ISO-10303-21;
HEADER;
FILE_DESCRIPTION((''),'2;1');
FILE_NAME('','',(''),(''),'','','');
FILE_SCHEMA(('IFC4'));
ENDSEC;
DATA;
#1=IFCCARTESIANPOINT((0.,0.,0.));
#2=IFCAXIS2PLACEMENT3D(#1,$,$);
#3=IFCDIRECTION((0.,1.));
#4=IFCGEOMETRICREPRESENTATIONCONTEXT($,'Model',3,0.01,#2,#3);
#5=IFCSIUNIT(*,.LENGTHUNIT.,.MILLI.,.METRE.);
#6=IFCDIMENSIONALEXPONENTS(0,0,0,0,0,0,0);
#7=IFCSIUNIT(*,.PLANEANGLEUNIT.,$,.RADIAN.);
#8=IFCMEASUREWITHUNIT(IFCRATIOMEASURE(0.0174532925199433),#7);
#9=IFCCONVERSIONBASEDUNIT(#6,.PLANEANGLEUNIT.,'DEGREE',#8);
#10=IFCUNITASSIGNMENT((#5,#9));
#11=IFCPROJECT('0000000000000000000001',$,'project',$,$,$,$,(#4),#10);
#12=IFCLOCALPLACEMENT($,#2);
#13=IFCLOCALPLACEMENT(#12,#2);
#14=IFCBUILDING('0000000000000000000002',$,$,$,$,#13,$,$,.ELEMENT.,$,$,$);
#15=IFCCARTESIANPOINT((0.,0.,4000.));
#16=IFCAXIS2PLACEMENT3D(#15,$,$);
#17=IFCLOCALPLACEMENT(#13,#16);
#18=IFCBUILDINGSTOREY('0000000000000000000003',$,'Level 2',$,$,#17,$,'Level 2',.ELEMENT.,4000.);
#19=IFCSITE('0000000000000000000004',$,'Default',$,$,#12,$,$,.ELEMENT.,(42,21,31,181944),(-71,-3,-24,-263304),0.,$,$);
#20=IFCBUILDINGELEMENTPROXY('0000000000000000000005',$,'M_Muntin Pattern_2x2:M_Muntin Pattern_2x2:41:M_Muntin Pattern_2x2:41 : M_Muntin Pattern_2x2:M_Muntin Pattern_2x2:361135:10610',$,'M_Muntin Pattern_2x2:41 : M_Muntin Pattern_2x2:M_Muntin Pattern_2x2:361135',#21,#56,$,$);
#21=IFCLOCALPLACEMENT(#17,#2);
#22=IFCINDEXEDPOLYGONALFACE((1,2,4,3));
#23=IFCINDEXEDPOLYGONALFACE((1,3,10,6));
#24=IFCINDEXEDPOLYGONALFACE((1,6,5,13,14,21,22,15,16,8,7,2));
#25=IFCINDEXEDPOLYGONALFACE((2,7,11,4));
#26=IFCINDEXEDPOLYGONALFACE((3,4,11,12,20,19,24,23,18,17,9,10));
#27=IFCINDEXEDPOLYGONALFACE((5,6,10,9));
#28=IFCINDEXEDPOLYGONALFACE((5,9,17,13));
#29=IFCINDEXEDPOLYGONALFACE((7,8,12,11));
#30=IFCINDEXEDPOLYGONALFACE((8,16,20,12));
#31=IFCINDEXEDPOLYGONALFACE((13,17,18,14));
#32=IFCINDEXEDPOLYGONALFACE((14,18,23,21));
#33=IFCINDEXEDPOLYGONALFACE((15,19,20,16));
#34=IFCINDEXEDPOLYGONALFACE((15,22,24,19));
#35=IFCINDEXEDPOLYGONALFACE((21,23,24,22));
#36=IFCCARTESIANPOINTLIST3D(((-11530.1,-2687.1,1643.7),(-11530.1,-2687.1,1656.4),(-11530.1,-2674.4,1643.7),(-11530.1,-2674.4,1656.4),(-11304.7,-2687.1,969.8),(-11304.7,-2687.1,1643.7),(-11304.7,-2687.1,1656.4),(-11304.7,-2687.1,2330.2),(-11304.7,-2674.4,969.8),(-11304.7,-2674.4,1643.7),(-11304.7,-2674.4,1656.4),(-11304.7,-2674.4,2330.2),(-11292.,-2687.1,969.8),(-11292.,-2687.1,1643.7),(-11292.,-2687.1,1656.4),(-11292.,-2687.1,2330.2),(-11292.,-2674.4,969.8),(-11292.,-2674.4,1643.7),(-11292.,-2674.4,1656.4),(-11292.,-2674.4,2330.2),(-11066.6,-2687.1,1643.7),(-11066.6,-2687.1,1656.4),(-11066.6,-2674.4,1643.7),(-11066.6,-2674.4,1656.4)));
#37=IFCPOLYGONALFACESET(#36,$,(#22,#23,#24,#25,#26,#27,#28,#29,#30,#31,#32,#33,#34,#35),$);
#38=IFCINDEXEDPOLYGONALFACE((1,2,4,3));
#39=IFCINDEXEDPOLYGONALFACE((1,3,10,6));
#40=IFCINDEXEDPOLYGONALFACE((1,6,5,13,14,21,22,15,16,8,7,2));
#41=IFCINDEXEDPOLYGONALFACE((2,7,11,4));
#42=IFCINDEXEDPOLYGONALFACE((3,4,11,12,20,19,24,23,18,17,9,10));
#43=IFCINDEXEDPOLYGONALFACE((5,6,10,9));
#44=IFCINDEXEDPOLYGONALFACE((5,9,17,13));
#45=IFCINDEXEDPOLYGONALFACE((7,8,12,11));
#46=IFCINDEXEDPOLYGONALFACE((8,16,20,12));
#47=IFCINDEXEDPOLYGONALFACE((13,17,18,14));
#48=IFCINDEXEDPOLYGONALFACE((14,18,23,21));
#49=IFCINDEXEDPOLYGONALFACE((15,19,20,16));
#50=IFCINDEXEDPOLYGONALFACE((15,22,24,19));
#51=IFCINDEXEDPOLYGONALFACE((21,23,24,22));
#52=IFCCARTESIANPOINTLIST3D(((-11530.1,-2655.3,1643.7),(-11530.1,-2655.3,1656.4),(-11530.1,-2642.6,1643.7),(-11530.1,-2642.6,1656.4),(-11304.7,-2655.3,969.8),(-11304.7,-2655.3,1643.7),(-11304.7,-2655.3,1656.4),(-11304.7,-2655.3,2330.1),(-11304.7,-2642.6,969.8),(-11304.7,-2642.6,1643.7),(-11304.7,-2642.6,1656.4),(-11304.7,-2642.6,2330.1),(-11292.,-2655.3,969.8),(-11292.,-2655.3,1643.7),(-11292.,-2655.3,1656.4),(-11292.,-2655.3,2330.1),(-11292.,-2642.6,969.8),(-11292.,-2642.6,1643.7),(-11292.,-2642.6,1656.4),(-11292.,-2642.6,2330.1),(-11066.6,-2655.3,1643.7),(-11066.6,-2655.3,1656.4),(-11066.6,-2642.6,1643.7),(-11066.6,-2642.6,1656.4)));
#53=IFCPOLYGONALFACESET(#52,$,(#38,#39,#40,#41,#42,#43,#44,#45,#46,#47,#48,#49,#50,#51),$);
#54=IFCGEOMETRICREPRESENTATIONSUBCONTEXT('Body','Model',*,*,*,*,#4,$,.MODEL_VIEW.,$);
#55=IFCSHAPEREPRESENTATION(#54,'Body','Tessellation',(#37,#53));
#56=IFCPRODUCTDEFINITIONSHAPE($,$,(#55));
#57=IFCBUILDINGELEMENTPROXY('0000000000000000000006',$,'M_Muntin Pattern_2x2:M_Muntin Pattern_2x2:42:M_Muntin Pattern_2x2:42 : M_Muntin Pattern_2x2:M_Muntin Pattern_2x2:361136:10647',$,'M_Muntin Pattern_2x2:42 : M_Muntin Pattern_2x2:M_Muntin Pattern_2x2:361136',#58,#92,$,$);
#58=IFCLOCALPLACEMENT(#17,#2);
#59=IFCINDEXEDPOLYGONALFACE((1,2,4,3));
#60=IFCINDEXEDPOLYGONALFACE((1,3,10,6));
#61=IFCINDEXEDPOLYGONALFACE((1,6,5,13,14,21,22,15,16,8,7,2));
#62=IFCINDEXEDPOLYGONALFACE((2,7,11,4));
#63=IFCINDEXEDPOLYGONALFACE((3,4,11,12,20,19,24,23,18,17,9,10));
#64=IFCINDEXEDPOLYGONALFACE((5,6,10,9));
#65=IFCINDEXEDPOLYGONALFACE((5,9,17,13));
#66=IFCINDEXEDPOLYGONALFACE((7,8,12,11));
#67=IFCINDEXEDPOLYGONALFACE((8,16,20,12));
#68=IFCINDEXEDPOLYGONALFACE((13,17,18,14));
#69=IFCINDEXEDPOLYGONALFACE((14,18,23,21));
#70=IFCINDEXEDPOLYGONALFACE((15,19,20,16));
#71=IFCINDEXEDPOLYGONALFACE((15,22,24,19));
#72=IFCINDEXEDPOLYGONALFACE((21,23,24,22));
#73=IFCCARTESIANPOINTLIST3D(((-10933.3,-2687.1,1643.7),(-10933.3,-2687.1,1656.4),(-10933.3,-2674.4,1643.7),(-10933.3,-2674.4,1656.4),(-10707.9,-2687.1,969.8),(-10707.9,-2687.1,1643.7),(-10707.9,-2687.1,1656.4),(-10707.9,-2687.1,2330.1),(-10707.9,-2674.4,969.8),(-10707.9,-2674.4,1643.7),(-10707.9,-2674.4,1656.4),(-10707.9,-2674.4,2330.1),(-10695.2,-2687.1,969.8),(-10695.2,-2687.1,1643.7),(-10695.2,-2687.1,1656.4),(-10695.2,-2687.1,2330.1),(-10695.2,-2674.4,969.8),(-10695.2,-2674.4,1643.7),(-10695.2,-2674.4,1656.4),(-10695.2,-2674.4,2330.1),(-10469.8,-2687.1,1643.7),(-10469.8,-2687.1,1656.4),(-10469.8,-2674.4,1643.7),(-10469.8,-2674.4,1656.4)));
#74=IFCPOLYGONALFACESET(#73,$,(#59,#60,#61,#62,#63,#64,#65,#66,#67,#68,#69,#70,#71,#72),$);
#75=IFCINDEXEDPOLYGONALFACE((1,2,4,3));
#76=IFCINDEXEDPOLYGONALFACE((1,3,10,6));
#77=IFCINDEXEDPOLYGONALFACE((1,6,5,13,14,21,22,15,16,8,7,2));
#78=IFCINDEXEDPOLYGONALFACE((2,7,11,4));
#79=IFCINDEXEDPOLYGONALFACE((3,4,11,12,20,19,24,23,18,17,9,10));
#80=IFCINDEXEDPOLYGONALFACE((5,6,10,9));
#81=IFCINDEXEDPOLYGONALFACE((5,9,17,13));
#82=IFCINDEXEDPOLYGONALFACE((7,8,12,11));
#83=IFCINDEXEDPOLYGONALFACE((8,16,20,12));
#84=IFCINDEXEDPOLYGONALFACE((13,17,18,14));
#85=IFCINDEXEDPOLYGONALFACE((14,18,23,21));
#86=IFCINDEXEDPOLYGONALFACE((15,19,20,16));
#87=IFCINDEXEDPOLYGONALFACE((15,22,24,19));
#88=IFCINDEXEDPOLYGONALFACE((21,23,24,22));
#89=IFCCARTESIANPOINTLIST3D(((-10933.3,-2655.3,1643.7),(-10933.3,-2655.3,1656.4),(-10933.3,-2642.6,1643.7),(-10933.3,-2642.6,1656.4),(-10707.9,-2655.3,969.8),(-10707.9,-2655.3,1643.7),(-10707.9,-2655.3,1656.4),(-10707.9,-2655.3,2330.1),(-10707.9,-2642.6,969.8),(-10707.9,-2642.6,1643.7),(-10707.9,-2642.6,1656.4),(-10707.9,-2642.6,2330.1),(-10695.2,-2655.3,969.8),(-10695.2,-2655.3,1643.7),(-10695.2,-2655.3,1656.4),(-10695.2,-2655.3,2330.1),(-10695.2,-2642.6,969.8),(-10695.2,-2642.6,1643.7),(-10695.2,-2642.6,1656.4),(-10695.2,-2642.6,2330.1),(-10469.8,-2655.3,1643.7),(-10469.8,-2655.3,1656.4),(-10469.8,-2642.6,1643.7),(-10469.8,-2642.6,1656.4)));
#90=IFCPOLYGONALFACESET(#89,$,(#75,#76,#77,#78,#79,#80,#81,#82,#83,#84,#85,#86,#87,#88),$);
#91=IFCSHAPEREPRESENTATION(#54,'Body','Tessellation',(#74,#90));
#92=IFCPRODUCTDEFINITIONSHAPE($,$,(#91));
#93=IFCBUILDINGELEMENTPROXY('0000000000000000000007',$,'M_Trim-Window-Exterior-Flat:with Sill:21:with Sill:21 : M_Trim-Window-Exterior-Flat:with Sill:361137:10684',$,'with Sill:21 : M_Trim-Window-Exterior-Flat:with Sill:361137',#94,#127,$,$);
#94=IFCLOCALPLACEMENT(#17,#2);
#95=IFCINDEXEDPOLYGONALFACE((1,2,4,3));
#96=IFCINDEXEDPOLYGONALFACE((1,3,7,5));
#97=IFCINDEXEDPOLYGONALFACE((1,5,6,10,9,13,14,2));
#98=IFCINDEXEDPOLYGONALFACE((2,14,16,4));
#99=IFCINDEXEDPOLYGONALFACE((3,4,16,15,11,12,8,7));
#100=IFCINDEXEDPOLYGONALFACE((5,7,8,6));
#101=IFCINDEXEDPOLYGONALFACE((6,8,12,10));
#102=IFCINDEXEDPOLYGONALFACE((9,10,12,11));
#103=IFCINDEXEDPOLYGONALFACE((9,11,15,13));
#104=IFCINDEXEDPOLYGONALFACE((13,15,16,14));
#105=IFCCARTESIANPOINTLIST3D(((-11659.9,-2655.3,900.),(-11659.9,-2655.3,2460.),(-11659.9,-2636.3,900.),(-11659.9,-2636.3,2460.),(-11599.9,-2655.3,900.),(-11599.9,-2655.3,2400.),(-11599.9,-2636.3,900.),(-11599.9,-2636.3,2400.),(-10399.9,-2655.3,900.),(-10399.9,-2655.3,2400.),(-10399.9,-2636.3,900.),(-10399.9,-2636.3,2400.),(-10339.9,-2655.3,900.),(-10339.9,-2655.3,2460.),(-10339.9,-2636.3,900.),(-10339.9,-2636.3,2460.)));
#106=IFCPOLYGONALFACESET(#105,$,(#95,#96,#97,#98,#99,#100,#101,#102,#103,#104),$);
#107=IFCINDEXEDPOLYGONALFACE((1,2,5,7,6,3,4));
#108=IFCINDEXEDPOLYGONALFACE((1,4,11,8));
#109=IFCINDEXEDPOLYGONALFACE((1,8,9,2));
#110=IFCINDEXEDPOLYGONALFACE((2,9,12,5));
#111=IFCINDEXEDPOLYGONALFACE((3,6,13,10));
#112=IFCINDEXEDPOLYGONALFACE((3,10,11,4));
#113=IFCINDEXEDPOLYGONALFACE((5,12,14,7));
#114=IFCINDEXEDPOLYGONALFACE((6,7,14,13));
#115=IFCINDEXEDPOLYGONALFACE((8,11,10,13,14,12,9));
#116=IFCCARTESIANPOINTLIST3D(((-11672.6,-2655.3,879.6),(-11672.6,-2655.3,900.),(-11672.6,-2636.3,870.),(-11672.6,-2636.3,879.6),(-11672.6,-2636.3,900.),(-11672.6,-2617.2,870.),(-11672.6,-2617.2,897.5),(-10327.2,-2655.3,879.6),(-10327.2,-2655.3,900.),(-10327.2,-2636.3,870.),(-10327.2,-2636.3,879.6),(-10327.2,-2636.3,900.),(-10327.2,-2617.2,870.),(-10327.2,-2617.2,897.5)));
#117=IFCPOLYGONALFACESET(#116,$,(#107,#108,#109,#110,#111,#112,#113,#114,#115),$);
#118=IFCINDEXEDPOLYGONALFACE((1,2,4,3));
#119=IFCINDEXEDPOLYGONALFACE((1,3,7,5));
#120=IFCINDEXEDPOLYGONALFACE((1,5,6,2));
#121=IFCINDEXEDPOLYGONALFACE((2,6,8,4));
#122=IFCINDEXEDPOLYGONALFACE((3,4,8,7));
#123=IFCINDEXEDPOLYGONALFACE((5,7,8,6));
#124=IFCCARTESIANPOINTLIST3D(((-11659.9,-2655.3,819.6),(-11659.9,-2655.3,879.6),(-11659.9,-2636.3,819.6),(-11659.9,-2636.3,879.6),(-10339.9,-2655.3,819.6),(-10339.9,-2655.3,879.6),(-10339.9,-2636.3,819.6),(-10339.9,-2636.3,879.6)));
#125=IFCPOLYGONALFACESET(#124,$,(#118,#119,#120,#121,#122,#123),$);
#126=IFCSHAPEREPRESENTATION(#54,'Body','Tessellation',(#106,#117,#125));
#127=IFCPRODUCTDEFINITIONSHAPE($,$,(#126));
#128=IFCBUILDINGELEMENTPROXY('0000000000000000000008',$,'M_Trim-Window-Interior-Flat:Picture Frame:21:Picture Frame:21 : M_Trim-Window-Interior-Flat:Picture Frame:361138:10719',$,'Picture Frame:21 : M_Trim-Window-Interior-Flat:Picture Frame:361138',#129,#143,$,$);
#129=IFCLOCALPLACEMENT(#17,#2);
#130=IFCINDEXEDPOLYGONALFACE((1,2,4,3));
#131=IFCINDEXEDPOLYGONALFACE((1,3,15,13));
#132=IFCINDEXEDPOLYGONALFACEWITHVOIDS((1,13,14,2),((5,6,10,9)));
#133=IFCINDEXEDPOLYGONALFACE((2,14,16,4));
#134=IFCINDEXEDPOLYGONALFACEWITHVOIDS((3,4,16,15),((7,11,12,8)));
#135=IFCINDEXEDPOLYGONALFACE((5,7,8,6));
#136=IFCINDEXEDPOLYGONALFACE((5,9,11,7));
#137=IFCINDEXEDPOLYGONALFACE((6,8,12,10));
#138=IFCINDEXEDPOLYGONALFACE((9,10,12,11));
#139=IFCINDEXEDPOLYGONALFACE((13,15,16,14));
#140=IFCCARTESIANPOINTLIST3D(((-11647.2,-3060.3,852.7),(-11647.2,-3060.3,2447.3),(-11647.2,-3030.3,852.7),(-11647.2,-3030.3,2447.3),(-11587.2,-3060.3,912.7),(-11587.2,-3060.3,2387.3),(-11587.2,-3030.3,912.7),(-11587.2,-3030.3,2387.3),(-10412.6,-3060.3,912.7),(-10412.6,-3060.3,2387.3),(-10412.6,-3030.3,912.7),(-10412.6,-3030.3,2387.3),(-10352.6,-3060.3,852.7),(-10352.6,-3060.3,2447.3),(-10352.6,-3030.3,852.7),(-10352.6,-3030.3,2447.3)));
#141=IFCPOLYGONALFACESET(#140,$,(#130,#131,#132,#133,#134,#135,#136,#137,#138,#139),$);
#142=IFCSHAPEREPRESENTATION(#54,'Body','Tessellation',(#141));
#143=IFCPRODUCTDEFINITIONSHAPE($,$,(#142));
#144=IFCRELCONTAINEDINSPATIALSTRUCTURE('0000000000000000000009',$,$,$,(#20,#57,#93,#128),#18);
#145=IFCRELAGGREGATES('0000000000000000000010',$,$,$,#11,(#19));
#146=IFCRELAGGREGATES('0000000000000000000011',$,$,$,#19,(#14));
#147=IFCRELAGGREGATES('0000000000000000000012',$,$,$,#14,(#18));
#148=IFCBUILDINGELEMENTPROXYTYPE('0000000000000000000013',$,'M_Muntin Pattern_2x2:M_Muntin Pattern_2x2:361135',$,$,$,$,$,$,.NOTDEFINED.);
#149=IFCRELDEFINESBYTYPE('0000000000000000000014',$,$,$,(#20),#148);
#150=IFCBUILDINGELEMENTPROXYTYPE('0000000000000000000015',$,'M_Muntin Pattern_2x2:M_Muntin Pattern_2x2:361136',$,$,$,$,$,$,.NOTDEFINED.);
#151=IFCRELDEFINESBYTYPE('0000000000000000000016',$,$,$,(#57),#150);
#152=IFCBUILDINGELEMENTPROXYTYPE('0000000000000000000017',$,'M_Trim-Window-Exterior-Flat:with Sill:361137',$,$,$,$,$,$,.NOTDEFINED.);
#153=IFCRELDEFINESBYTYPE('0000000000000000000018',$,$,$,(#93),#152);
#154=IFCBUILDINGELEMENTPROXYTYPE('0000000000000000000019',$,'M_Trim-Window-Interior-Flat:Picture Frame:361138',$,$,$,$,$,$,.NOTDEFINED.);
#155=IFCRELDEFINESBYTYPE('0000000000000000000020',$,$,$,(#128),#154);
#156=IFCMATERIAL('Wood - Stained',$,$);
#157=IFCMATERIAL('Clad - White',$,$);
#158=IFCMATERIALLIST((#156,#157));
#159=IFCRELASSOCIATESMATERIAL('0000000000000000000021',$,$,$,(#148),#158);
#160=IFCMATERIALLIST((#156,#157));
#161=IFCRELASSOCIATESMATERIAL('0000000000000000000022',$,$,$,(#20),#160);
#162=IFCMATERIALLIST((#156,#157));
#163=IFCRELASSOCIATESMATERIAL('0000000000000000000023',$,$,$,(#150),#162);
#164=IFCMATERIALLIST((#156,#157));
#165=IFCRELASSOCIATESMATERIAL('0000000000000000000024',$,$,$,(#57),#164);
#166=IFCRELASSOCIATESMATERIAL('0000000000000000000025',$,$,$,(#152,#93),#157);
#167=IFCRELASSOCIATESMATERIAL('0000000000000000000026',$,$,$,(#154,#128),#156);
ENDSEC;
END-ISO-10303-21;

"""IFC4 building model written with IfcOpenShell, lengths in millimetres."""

from ifc_helpers import new_model, entity, si_unit, converted_unit, direction, frame, origin, origin_2d_with_axis, place, context, subcontext, project, spatial, polyline, rectangle, outline, extrude, source, transform, mapped, material, material_list, type_object, type_shapes, element, save


model = new_model("IFC4")

# Units and contexts
model_context = context("Model", 3, precision=0.01, world=origin(), true_north=direction((0.0, 1.0)))
body_context = subcontext(model_context, "Body", "Model", "MODEL_VIEW")
ifc_project = project(units=[si_unit("LENGTHUNIT", "METRE", prefix="MILLI"), converted_unit("PLANEANGLEUNIT", "DEGREE", entity("IfcRatioMeasure", 0.0174532925199433), si_unit("PLANEANGLEUNIT", "RADIAN"), dimensions=[0, 0, 0, 0, 0, 0, 0])], contexts=[model_context])

# Site, building, storey
site_placement = place(None, origin())
site = spatial("IfcSite", under=ifc_project, at=site_placement, Name="Default", CompositionType="ELEMENT", RefLatitude=(42, 21, 31, 181944), RefLongitude=(-71, -3, -24, -263304), RefElevation=0.0)
building_placement = place(site_placement, origin())
building = spatial("IfcBuilding", under=site, at=building_placement, CompositionType="ELEMENT")
storey_placement = place(building_placement, frame((0.0, 0.0, 4000.0)))
storey = spatial("IfcBuildingStorey", under=building, at=storey_placement, Name="Level 2", LongName="Level 2", CompositionType="ELEMENT", Elevation=4000.0)

# Building element proxies
ifc_material_1 = material(Name="Wood - Stained")
ifc_material_2 = material(Name="Clad - White")
ifc_material_list_1 = material_list([ifc_material_1, ifc_material_2])
ifc_material_list_2 = material_list([ifc_material_1, ifc_material_2])
building_element_proxy_type_1 = type_object("IfcBuildingElementProxyType", Name="M_Muntin Pattern_2x2:M_Muntin Pattern_2x2:361135", PredefinedType="NOTDEFINED", material=ifc_material_list_2)
shared_shape_1 = source(origin(), body_context, "Body", "SweptSolid", [
    extrude(outline(polyline([(-6.4, -680.2), (6.3, -680.2), (6.3, -6.4), (231.7, -6.4), (231.7, 6.3), (6.3, 6.3), (6.3, 680.2), (-6.4, 680.2), (-6.4, 6.3), (-231.7, 6.3), (-231.7, -6.4), (-6.4, -6.4), (-6.4, -680.2)])), frame((-11298.4, -2687.1, 5650.0), z_axis=(0.0, 1.0, 0.0), x_axis=(1.0, 0.0, 0.0)), (0.0, 0.0, 1.0), 12.7),
    extrude(outline(polyline([(-6.4, -680.1), (6.3, -680.1), (6.3, -6.4), (231.7, -6.4), (231.7, 6.3), (6.3, 6.3), (6.3, 680.2), (-6.4, 680.2), (-6.4, 6.3), (-231.7, 6.3), (-231.7, -6.4), (-6.4, -6.4), (-6.4, -680.1)])), frame((-11298.4, -2655.3, 5650.0), z_axis=(0.0, 1.0, 0.0), x_axis=(1.0, 0.0, 0.0)), (0.0, 0.0, 1.0), 12.7),
])
type_shapes(building_element_proxy_type_1, [shared_shape_1])
proxy_1_placement = place(storey_placement, frame((0.0, 0.0, -4000.0)))
element("IfcBuildingElementProxy", 1, at=proxy_1_placement, inside=storey, type_object=building_element_proxy_type_1, material=ifc_material_list_1, Name="M_Muntin Pattern_2x2:M_Muntin Pattern_2x2:41:M_Muntin Pattern_2x2:41 : M_Muntin Pattern_2x2:M_Muntin Pattern_2x2:361135:10610", ObjectType="M_Muntin Pattern_2x2:41 : M_Muntin Pattern_2x2:M_Muntin Pattern_2x2:361135", context=body_context, shape_type="MappedRepresentation", body=[
    mapped(shared_shape_1, transform((0.0, 0.0, 0.0), scale=1.0)),
])
ifc_material_list_3 = material_list([ifc_material_1, ifc_material_2])
ifc_material_list_4 = material_list([ifc_material_1, ifc_material_2])
building_element_proxy_type_2 = type_object("IfcBuildingElementProxyType", Name="M_Muntin Pattern_2x2:M_Muntin Pattern_2x2:361136", PredefinedType="NOTDEFINED", material=ifc_material_list_4)
shared_shape_2 = source(origin(), body_context, "Body", "SweptSolid", [
    extrude(outline(polyline([(-680.1, 6.4), (-680.1, -6.3), (-6.4, -6.3), (-6.4, -231.7), (6.3, -231.7), (6.3, -6.3), (680.2, -6.3), (680.2, 6.4), (6.3, 6.4), (6.3, 231.7), (-6.4, 231.7), (-6.4, 6.4), (-680.1, 6.4)])), frame((-10701.5, -2687.1, 5650.0), z_axis=(0.0, -1.0, 0.0), x_axis=(0.0, 0.0, -1.0)), (0.0, 0.0, -1.0), 12.7),
    extrude(outline(polyline([(-680.1, 6.4), (-680.1, -6.3), (-6.4, -6.3), (-6.4, -231.7), (6.3, -231.7), (6.3, -6.3), (680.2, -6.3), (680.2, 6.4), (6.3, 6.4), (6.3, 231.7), (-6.4, 231.7), (-6.4, 6.4), (-680.1, 6.4)])), frame((-10701.5, -2655.3, 5650.0), z_axis=(0.0, -1.0, 0.0), x_axis=(0.0, 0.0, -1.0)), (0.0, 0.0, -1.0), 12.7),
])
type_shapes(building_element_proxy_type_2, [shared_shape_2])
proxy_2_placement = place(storey_placement, frame((0.0, 0.0, -4000.0)))
element("IfcBuildingElementProxy", 2, at=proxy_2_placement, inside=storey, type_object=building_element_proxy_type_2, material=ifc_material_list_3, Name="M_Muntin Pattern_2x2:M_Muntin Pattern_2x2:42:M_Muntin Pattern_2x2:42 : M_Muntin Pattern_2x2:M_Muntin Pattern_2x2:361136:10647", ObjectType="M_Muntin Pattern_2x2:42 : M_Muntin Pattern_2x2:M_Muntin Pattern_2x2:361136", context=body_context, shape_type="MappedRepresentation", body=[
    mapped(shared_shape_2, transform((0.0, 0.0, 0.0), scale=1.0)),
])
building_element_proxy_type_3 = type_object("IfcBuildingElementProxyType", Name="M_Trim-Window-Exterior-Flat:with Sill:361137", PredefinedType="NOTDEFINED", material=ifc_material_2)
shared_shape_3 = source(origin(), body_context, "Body", "SweptSolid", [
    extrude(outline(polyline([(-660.0, -765.0), (-600.0, -765.0), (-600.0, 735.0), (600.0, 735.0), (600.0, -765.0), (660.0, -765.0), (660.0, 795.0), (-660.0, 795.0), (-660.0, -765.0)])), frame((-10999.9, -2655.3, 5665.0), z_axis=(0.0, 1.0, 0.0), x_axis=(-1.0, 0.0, 0.0)), (0.0, 0.0, 1.0), 19.1),
    extrude(outline(polyline([(0.0, -15.2), (19.0, -15.2), (19.0, 12.3), (0.0, 14.8), (-19.0, 14.8), (-19.0, -5.7), (0.0, -5.7), (0.0, -15.2)])), frame((-11672.6, -2636.3, 4885.2), z_axis=(1.0, 0.0, 0.0), x_axis=(0.0, 1.0, 0.0)), (0.0, 0.0, 1.0), 1345.4),
    extrude(rectangle(XDim=19.1, YDim=1320.0, at=origin_2d_with_axis()), frame((-10999.9, -2645.8, 4819.6), z_axis=(0.0, 0.0, 1.0), x_axis=(0.0, -1.0, 0.0)), (0.0, 0.0, 1.0), 60.0),
])
type_shapes(building_element_proxy_type_3, [shared_shape_3])
proxy_3_placement = place(storey_placement, frame((0.0, 0.0, -4000.0)))
element("IfcBuildingElementProxy", 3, at=proxy_3_placement, inside=storey, type_object=building_element_proxy_type_3, material=ifc_material_2, Name="M_Trim-Window-Exterior-Flat:with Sill:21:with Sill:21 : M_Trim-Window-Exterior-Flat:with Sill:361137:10684", ObjectType="with Sill:21 : M_Trim-Window-Exterior-Flat:with Sill:361137", context=body_context, shape_type="MappedRepresentation", body=[
    mapped(shared_shape_3, transform((0.0, 0.0, 0.0), scale=1.0)),
])
building_element_proxy_type_4 = type_object("IfcBuildingElementProxyType", Name="M_Trim-Window-Interior-Flat:Picture Frame:361138", PredefinedType="NOTDEFINED", material=ifc_material_1)
shared_shape_4 = source(origin(), body_context, "Body", "SweptSolid", [
    extrude(outline(polyline([(-647.3, -797.3), (647.3, -797.3), (647.3, 797.3), (-647.3, 797.3), (-647.3, -797.3)]), holes=[polyline([(587.3, 737.3), (587.3, -737.3), (-587.3, -737.3), (-587.3, 737.3), (587.3, 737.3)])]), frame((-10999.9, -3060.3, 5650.0), z_axis=(0.0, 1.0, 0.0), x_axis=(1.0, 0.0, 0.0)), (0.0, 0.0, 1.0), 30.0),
])
type_shapes(building_element_proxy_type_4, [shared_shape_4])
proxy_4_placement = place(storey_placement, frame((0.0, 0.0, -4000.0)))
element("IfcBuildingElementProxy", 4, at=proxy_4_placement, inside=storey, type_object=building_element_proxy_type_4, material=ifc_material_1, Name="M_Trim-Window-Interior-Flat:Picture Frame:21:Picture Frame:21 : M_Trim-Window-Interior-Flat:Picture Frame:361138:10719", ObjectType="Picture Frame:21 : M_Trim-Window-Interior-Flat:Picture Frame:361138", context=body_context, shape_type="MappedRepresentation", body=[
    mapped(shared_shape_4, transform((0.0, 0.0, 0.0), scale=1.0)),
])

save(model, "model.ifc")
